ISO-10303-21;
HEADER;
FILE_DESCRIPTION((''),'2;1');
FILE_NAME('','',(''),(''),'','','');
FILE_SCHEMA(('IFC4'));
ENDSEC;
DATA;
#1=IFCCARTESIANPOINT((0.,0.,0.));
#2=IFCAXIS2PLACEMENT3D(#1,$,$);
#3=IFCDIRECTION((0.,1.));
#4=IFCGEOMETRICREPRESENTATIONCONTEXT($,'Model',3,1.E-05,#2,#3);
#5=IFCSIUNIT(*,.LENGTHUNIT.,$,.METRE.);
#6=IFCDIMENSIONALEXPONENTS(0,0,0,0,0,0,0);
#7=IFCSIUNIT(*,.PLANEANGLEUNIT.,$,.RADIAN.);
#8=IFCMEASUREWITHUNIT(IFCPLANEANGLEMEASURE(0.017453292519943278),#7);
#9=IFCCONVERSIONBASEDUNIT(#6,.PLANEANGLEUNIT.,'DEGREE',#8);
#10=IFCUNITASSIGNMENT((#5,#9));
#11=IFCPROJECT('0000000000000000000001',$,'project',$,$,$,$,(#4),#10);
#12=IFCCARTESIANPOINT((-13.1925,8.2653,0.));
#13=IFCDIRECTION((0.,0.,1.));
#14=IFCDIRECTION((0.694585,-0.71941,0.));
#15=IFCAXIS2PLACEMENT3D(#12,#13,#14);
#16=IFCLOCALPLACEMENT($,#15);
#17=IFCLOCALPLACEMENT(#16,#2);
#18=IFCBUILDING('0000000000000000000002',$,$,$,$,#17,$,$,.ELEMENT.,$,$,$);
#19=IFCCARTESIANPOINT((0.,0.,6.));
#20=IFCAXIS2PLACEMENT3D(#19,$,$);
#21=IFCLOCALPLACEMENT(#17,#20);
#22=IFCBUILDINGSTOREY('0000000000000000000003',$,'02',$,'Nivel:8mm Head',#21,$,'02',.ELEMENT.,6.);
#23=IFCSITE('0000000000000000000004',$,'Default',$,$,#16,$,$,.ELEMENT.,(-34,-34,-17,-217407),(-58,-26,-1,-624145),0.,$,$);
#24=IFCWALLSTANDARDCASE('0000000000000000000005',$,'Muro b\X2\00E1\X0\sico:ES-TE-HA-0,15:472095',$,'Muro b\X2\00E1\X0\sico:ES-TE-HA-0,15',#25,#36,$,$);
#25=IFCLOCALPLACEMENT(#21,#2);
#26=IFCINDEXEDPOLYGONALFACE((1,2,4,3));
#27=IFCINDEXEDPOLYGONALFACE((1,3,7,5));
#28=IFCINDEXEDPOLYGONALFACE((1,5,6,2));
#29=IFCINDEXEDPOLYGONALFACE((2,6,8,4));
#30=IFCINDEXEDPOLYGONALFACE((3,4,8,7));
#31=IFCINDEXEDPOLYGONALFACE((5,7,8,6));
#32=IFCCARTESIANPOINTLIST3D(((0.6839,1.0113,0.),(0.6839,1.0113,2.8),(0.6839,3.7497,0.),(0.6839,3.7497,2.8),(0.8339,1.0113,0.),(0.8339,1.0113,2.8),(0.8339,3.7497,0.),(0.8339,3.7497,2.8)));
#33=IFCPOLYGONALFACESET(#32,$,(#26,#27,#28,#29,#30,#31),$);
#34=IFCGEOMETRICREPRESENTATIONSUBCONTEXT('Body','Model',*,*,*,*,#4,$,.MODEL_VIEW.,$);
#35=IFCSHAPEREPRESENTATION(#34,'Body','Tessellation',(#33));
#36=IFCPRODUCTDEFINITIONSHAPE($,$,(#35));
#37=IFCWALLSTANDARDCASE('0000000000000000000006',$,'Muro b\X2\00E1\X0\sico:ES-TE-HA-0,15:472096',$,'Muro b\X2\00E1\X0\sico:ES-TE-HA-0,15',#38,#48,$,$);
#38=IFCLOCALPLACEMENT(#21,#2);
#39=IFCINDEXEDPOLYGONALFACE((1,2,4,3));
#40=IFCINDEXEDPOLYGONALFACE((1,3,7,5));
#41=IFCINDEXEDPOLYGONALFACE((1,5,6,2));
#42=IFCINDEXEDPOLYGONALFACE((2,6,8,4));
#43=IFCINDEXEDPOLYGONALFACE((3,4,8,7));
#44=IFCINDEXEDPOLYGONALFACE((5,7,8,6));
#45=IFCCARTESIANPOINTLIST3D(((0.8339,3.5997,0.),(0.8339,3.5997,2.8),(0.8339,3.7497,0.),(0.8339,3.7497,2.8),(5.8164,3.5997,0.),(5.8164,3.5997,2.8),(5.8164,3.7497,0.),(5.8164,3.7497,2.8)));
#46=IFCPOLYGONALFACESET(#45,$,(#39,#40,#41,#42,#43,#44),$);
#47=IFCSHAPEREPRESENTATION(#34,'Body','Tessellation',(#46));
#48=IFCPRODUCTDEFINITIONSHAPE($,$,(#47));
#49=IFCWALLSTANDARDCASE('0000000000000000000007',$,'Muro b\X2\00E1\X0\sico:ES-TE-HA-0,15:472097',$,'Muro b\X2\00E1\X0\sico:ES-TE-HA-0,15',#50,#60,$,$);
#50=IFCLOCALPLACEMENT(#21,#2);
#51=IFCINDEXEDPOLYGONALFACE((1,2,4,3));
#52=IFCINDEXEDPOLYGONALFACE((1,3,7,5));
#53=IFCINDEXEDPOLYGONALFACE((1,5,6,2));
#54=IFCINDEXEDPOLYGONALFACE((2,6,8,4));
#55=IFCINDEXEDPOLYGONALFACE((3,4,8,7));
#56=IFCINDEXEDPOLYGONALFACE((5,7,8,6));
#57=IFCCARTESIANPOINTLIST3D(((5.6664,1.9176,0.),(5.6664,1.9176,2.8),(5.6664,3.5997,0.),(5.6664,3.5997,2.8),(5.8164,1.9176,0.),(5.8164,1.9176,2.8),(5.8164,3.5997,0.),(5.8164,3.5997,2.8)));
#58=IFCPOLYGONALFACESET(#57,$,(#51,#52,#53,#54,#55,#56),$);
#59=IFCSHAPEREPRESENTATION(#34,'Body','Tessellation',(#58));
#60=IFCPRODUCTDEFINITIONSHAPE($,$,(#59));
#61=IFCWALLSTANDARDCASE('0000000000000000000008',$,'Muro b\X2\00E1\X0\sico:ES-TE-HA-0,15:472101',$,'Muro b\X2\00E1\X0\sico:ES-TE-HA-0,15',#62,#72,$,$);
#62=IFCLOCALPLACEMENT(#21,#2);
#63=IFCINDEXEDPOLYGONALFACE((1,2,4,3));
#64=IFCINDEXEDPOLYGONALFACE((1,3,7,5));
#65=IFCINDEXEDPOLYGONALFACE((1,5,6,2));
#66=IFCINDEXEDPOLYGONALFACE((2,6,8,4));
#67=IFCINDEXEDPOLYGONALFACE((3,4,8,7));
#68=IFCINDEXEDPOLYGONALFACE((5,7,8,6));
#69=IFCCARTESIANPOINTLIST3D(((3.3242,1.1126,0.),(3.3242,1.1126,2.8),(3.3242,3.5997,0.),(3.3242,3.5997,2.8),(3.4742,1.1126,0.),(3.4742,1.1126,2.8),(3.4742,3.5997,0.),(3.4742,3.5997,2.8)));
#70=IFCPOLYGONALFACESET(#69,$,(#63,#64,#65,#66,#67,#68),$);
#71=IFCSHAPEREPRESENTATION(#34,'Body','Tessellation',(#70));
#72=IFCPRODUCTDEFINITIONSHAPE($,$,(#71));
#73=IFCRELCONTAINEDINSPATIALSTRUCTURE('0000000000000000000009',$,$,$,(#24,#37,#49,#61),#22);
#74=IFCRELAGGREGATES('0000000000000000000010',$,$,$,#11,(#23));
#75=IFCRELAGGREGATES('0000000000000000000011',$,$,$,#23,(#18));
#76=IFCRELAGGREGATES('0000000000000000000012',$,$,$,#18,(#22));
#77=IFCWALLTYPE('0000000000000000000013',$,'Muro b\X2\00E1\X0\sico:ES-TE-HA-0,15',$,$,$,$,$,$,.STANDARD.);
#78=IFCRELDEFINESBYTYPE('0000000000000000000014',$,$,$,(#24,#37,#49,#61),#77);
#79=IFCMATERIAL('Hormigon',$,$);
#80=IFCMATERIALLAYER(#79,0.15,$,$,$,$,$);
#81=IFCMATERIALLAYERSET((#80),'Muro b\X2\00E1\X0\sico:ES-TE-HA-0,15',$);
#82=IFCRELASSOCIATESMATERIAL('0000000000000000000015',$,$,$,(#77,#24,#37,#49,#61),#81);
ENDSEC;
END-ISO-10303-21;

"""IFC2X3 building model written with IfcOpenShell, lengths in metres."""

from ifc_helpers import new_model, entity, si_unit, converted_unit, direction, frame, frame_2d, origin, place, context, subcontext, project, spatial, rectangle, extrude, material, layer, layer_set, layer_usage, type_object, element, save


model = new_model("IFC2X3")

# Units and contexts
model_context = context("Model", 3, precision=1e-05, world=origin(), true_north=direction((0.0, 1.0)))
body_context = subcontext(model_context, "Body", "Model", "MODEL_VIEW")
ifc_project = project(units=[si_unit("LENGTHUNIT", "METRE"), converted_unit("PLANEANGLEUNIT", "DEGREE", entity("IfcPlaneAngleMeasure", 0.017453292519943278), si_unit("PLANEANGLEUNIT", "RADIAN"), dimensions=[0, 0, 0, 0, 0, 0, 0])], contexts=[model_context])

# Site, building, storey
site_placement = place(None, frame((-13.1925, 8.2653, 0.0), z_axis=(0.0, 0.0, 1.0), x_axis=(0.694585, -0.71941, 0.0)))
site = spatial("IfcSite", under=ifc_project, at=site_placement, Name="Default", CompositionType="ELEMENT", RefLatitude=(-34, -34, -17, -217407), RefLongitude=(-58, -26, -1, -624145), RefElevation=0.0)
building_placement = place(site_placement, origin())
building = spatial("IfcBuilding", under=site, at=building_placement, CompositionType="ELEMENT")
storey_placement = place(building_placement, frame((0.0, 0.0, 6.0)))
storey = spatial("IfcBuildingStorey", under=building, at=storey_placement, Name="02", ObjectType="Nivel:8mm Head", LongName="02", CompositionType="ELEMENT", Elevation=6.0)

# Shared definitions
ifc_material_1 = material(Name="Hormigon")

# Walls
ifc_layer_1 = layer(ifc_material_1, 0.15)
ifc_layer_set_1 = layer_set([ifc_layer_1], Name="Muro básico:ES-TE-HA-0,15")
ifc_layer_usage_1 = layer_usage(ifc_layer_set_1, "AXIS2", "NEGATIVE", 0.075)
wall_type = type_object("IfcWallType", Name="Muro básico:ES-TE-HA-0,15", PredefinedType="STANDARD", material=ifc_layer_set_1)
wall_1_placement = place(storey_placement, frame((0.7589, 1.0113, 0.0), z_axis=(0.0, 0.0, 1.0), x_axis=(0.0, 1.0, 0.0)))
element("IfcWallStandardCase", 1, at=wall_1_placement, inside=storey, type_object=wall_type, material=ifc_layer_usage_1, Name="Muro básico:ES-TE-HA-0,15:472095", ObjectType="Muro básico:ES-TE-HA-0,15", context=body_context, shape_type="SweptSolid", body=[
    extrude(rectangle(XDim=2.7384, YDim=0.15, at=frame_2d((1.3692, 0.0), x_axis=(-1.0, 0.0))), origin(), (0.0, 0.0, 1.0), 2.8),
])
ifc_layer_usage_2 = layer_usage(ifc_layer_set_1, "AXIS2", "NEGATIVE", 0.075)
wall_2_placement = place(storey_placement, frame((0.8339, 3.6747, 0.0)))
element("IfcWallStandardCase", 2, at=wall_2_placement, inside=storey, type_object=wall_type, material=ifc_layer_usage_2, Name="Muro básico:ES-TE-HA-0,15:472096", ObjectType="Muro básico:ES-TE-HA-0,15", context=body_context, shape_type="SweptSolid", body=[
    extrude(rectangle(XDim=4.9825, YDim=0.15, at=frame_2d((2.4912, 0.0), x_axis=(-1.0, 0.0))), origin(), (0.0, 0.0, 1.0), 2.8),
])
ifc_layer_usage_3 = layer_usage(ifc_layer_set_1, "AXIS2", "NEGATIVE", 0.075)
wall_3_placement = place(storey_placement, frame((5.7414, 1.9176, 0.0), z_axis=(0.0, 0.0, 1.0), x_axis=(0.0, 1.0, 0.0)))
element("IfcWallStandardCase", 3, at=wall_3_placement, inside=storey, type_object=wall_type, material=ifc_layer_usage_3, Name="Muro básico:ES-TE-HA-0,15:472097", ObjectType="Muro básico:ES-TE-HA-0,15", context=body_context, shape_type="SweptSolid", body=[
    extrude(rectangle(XDim=1.682, YDim=0.15, at=frame_2d((0.841, 0.0), x_axis=(-1.0, 0.0))), origin(), (0.0, 0.0, 1.0), 2.8),
])
ifc_layer_usage_4 = layer_usage(ifc_layer_set_1, "AXIS2", "NEGATIVE", 0.075)
wall_4_placement = place(storey_placement, frame((3.3992, 3.5997, 0.0), z_axis=(0.0, 0.0, 1.0), x_axis=(0.0, -1.0, 0.0)))
element("IfcWallStandardCase", 4, at=wall_4_placement, inside=storey, type_object=wall_type, material=ifc_layer_usage_4, Name="Muro básico:ES-TE-HA-0,15:472101", ObjectType="Muro básico:ES-TE-HA-0,15", context=body_context, shape_type="SweptSolid", body=[
    extrude(rectangle(XDim=2.487, YDim=0.15, at=frame_2d((1.2435, 0.0), x_axis=(-1.0, 0.0))), origin(), (0.0, 0.0, 1.0), 2.8),
])

save(model, "model.ifc")
